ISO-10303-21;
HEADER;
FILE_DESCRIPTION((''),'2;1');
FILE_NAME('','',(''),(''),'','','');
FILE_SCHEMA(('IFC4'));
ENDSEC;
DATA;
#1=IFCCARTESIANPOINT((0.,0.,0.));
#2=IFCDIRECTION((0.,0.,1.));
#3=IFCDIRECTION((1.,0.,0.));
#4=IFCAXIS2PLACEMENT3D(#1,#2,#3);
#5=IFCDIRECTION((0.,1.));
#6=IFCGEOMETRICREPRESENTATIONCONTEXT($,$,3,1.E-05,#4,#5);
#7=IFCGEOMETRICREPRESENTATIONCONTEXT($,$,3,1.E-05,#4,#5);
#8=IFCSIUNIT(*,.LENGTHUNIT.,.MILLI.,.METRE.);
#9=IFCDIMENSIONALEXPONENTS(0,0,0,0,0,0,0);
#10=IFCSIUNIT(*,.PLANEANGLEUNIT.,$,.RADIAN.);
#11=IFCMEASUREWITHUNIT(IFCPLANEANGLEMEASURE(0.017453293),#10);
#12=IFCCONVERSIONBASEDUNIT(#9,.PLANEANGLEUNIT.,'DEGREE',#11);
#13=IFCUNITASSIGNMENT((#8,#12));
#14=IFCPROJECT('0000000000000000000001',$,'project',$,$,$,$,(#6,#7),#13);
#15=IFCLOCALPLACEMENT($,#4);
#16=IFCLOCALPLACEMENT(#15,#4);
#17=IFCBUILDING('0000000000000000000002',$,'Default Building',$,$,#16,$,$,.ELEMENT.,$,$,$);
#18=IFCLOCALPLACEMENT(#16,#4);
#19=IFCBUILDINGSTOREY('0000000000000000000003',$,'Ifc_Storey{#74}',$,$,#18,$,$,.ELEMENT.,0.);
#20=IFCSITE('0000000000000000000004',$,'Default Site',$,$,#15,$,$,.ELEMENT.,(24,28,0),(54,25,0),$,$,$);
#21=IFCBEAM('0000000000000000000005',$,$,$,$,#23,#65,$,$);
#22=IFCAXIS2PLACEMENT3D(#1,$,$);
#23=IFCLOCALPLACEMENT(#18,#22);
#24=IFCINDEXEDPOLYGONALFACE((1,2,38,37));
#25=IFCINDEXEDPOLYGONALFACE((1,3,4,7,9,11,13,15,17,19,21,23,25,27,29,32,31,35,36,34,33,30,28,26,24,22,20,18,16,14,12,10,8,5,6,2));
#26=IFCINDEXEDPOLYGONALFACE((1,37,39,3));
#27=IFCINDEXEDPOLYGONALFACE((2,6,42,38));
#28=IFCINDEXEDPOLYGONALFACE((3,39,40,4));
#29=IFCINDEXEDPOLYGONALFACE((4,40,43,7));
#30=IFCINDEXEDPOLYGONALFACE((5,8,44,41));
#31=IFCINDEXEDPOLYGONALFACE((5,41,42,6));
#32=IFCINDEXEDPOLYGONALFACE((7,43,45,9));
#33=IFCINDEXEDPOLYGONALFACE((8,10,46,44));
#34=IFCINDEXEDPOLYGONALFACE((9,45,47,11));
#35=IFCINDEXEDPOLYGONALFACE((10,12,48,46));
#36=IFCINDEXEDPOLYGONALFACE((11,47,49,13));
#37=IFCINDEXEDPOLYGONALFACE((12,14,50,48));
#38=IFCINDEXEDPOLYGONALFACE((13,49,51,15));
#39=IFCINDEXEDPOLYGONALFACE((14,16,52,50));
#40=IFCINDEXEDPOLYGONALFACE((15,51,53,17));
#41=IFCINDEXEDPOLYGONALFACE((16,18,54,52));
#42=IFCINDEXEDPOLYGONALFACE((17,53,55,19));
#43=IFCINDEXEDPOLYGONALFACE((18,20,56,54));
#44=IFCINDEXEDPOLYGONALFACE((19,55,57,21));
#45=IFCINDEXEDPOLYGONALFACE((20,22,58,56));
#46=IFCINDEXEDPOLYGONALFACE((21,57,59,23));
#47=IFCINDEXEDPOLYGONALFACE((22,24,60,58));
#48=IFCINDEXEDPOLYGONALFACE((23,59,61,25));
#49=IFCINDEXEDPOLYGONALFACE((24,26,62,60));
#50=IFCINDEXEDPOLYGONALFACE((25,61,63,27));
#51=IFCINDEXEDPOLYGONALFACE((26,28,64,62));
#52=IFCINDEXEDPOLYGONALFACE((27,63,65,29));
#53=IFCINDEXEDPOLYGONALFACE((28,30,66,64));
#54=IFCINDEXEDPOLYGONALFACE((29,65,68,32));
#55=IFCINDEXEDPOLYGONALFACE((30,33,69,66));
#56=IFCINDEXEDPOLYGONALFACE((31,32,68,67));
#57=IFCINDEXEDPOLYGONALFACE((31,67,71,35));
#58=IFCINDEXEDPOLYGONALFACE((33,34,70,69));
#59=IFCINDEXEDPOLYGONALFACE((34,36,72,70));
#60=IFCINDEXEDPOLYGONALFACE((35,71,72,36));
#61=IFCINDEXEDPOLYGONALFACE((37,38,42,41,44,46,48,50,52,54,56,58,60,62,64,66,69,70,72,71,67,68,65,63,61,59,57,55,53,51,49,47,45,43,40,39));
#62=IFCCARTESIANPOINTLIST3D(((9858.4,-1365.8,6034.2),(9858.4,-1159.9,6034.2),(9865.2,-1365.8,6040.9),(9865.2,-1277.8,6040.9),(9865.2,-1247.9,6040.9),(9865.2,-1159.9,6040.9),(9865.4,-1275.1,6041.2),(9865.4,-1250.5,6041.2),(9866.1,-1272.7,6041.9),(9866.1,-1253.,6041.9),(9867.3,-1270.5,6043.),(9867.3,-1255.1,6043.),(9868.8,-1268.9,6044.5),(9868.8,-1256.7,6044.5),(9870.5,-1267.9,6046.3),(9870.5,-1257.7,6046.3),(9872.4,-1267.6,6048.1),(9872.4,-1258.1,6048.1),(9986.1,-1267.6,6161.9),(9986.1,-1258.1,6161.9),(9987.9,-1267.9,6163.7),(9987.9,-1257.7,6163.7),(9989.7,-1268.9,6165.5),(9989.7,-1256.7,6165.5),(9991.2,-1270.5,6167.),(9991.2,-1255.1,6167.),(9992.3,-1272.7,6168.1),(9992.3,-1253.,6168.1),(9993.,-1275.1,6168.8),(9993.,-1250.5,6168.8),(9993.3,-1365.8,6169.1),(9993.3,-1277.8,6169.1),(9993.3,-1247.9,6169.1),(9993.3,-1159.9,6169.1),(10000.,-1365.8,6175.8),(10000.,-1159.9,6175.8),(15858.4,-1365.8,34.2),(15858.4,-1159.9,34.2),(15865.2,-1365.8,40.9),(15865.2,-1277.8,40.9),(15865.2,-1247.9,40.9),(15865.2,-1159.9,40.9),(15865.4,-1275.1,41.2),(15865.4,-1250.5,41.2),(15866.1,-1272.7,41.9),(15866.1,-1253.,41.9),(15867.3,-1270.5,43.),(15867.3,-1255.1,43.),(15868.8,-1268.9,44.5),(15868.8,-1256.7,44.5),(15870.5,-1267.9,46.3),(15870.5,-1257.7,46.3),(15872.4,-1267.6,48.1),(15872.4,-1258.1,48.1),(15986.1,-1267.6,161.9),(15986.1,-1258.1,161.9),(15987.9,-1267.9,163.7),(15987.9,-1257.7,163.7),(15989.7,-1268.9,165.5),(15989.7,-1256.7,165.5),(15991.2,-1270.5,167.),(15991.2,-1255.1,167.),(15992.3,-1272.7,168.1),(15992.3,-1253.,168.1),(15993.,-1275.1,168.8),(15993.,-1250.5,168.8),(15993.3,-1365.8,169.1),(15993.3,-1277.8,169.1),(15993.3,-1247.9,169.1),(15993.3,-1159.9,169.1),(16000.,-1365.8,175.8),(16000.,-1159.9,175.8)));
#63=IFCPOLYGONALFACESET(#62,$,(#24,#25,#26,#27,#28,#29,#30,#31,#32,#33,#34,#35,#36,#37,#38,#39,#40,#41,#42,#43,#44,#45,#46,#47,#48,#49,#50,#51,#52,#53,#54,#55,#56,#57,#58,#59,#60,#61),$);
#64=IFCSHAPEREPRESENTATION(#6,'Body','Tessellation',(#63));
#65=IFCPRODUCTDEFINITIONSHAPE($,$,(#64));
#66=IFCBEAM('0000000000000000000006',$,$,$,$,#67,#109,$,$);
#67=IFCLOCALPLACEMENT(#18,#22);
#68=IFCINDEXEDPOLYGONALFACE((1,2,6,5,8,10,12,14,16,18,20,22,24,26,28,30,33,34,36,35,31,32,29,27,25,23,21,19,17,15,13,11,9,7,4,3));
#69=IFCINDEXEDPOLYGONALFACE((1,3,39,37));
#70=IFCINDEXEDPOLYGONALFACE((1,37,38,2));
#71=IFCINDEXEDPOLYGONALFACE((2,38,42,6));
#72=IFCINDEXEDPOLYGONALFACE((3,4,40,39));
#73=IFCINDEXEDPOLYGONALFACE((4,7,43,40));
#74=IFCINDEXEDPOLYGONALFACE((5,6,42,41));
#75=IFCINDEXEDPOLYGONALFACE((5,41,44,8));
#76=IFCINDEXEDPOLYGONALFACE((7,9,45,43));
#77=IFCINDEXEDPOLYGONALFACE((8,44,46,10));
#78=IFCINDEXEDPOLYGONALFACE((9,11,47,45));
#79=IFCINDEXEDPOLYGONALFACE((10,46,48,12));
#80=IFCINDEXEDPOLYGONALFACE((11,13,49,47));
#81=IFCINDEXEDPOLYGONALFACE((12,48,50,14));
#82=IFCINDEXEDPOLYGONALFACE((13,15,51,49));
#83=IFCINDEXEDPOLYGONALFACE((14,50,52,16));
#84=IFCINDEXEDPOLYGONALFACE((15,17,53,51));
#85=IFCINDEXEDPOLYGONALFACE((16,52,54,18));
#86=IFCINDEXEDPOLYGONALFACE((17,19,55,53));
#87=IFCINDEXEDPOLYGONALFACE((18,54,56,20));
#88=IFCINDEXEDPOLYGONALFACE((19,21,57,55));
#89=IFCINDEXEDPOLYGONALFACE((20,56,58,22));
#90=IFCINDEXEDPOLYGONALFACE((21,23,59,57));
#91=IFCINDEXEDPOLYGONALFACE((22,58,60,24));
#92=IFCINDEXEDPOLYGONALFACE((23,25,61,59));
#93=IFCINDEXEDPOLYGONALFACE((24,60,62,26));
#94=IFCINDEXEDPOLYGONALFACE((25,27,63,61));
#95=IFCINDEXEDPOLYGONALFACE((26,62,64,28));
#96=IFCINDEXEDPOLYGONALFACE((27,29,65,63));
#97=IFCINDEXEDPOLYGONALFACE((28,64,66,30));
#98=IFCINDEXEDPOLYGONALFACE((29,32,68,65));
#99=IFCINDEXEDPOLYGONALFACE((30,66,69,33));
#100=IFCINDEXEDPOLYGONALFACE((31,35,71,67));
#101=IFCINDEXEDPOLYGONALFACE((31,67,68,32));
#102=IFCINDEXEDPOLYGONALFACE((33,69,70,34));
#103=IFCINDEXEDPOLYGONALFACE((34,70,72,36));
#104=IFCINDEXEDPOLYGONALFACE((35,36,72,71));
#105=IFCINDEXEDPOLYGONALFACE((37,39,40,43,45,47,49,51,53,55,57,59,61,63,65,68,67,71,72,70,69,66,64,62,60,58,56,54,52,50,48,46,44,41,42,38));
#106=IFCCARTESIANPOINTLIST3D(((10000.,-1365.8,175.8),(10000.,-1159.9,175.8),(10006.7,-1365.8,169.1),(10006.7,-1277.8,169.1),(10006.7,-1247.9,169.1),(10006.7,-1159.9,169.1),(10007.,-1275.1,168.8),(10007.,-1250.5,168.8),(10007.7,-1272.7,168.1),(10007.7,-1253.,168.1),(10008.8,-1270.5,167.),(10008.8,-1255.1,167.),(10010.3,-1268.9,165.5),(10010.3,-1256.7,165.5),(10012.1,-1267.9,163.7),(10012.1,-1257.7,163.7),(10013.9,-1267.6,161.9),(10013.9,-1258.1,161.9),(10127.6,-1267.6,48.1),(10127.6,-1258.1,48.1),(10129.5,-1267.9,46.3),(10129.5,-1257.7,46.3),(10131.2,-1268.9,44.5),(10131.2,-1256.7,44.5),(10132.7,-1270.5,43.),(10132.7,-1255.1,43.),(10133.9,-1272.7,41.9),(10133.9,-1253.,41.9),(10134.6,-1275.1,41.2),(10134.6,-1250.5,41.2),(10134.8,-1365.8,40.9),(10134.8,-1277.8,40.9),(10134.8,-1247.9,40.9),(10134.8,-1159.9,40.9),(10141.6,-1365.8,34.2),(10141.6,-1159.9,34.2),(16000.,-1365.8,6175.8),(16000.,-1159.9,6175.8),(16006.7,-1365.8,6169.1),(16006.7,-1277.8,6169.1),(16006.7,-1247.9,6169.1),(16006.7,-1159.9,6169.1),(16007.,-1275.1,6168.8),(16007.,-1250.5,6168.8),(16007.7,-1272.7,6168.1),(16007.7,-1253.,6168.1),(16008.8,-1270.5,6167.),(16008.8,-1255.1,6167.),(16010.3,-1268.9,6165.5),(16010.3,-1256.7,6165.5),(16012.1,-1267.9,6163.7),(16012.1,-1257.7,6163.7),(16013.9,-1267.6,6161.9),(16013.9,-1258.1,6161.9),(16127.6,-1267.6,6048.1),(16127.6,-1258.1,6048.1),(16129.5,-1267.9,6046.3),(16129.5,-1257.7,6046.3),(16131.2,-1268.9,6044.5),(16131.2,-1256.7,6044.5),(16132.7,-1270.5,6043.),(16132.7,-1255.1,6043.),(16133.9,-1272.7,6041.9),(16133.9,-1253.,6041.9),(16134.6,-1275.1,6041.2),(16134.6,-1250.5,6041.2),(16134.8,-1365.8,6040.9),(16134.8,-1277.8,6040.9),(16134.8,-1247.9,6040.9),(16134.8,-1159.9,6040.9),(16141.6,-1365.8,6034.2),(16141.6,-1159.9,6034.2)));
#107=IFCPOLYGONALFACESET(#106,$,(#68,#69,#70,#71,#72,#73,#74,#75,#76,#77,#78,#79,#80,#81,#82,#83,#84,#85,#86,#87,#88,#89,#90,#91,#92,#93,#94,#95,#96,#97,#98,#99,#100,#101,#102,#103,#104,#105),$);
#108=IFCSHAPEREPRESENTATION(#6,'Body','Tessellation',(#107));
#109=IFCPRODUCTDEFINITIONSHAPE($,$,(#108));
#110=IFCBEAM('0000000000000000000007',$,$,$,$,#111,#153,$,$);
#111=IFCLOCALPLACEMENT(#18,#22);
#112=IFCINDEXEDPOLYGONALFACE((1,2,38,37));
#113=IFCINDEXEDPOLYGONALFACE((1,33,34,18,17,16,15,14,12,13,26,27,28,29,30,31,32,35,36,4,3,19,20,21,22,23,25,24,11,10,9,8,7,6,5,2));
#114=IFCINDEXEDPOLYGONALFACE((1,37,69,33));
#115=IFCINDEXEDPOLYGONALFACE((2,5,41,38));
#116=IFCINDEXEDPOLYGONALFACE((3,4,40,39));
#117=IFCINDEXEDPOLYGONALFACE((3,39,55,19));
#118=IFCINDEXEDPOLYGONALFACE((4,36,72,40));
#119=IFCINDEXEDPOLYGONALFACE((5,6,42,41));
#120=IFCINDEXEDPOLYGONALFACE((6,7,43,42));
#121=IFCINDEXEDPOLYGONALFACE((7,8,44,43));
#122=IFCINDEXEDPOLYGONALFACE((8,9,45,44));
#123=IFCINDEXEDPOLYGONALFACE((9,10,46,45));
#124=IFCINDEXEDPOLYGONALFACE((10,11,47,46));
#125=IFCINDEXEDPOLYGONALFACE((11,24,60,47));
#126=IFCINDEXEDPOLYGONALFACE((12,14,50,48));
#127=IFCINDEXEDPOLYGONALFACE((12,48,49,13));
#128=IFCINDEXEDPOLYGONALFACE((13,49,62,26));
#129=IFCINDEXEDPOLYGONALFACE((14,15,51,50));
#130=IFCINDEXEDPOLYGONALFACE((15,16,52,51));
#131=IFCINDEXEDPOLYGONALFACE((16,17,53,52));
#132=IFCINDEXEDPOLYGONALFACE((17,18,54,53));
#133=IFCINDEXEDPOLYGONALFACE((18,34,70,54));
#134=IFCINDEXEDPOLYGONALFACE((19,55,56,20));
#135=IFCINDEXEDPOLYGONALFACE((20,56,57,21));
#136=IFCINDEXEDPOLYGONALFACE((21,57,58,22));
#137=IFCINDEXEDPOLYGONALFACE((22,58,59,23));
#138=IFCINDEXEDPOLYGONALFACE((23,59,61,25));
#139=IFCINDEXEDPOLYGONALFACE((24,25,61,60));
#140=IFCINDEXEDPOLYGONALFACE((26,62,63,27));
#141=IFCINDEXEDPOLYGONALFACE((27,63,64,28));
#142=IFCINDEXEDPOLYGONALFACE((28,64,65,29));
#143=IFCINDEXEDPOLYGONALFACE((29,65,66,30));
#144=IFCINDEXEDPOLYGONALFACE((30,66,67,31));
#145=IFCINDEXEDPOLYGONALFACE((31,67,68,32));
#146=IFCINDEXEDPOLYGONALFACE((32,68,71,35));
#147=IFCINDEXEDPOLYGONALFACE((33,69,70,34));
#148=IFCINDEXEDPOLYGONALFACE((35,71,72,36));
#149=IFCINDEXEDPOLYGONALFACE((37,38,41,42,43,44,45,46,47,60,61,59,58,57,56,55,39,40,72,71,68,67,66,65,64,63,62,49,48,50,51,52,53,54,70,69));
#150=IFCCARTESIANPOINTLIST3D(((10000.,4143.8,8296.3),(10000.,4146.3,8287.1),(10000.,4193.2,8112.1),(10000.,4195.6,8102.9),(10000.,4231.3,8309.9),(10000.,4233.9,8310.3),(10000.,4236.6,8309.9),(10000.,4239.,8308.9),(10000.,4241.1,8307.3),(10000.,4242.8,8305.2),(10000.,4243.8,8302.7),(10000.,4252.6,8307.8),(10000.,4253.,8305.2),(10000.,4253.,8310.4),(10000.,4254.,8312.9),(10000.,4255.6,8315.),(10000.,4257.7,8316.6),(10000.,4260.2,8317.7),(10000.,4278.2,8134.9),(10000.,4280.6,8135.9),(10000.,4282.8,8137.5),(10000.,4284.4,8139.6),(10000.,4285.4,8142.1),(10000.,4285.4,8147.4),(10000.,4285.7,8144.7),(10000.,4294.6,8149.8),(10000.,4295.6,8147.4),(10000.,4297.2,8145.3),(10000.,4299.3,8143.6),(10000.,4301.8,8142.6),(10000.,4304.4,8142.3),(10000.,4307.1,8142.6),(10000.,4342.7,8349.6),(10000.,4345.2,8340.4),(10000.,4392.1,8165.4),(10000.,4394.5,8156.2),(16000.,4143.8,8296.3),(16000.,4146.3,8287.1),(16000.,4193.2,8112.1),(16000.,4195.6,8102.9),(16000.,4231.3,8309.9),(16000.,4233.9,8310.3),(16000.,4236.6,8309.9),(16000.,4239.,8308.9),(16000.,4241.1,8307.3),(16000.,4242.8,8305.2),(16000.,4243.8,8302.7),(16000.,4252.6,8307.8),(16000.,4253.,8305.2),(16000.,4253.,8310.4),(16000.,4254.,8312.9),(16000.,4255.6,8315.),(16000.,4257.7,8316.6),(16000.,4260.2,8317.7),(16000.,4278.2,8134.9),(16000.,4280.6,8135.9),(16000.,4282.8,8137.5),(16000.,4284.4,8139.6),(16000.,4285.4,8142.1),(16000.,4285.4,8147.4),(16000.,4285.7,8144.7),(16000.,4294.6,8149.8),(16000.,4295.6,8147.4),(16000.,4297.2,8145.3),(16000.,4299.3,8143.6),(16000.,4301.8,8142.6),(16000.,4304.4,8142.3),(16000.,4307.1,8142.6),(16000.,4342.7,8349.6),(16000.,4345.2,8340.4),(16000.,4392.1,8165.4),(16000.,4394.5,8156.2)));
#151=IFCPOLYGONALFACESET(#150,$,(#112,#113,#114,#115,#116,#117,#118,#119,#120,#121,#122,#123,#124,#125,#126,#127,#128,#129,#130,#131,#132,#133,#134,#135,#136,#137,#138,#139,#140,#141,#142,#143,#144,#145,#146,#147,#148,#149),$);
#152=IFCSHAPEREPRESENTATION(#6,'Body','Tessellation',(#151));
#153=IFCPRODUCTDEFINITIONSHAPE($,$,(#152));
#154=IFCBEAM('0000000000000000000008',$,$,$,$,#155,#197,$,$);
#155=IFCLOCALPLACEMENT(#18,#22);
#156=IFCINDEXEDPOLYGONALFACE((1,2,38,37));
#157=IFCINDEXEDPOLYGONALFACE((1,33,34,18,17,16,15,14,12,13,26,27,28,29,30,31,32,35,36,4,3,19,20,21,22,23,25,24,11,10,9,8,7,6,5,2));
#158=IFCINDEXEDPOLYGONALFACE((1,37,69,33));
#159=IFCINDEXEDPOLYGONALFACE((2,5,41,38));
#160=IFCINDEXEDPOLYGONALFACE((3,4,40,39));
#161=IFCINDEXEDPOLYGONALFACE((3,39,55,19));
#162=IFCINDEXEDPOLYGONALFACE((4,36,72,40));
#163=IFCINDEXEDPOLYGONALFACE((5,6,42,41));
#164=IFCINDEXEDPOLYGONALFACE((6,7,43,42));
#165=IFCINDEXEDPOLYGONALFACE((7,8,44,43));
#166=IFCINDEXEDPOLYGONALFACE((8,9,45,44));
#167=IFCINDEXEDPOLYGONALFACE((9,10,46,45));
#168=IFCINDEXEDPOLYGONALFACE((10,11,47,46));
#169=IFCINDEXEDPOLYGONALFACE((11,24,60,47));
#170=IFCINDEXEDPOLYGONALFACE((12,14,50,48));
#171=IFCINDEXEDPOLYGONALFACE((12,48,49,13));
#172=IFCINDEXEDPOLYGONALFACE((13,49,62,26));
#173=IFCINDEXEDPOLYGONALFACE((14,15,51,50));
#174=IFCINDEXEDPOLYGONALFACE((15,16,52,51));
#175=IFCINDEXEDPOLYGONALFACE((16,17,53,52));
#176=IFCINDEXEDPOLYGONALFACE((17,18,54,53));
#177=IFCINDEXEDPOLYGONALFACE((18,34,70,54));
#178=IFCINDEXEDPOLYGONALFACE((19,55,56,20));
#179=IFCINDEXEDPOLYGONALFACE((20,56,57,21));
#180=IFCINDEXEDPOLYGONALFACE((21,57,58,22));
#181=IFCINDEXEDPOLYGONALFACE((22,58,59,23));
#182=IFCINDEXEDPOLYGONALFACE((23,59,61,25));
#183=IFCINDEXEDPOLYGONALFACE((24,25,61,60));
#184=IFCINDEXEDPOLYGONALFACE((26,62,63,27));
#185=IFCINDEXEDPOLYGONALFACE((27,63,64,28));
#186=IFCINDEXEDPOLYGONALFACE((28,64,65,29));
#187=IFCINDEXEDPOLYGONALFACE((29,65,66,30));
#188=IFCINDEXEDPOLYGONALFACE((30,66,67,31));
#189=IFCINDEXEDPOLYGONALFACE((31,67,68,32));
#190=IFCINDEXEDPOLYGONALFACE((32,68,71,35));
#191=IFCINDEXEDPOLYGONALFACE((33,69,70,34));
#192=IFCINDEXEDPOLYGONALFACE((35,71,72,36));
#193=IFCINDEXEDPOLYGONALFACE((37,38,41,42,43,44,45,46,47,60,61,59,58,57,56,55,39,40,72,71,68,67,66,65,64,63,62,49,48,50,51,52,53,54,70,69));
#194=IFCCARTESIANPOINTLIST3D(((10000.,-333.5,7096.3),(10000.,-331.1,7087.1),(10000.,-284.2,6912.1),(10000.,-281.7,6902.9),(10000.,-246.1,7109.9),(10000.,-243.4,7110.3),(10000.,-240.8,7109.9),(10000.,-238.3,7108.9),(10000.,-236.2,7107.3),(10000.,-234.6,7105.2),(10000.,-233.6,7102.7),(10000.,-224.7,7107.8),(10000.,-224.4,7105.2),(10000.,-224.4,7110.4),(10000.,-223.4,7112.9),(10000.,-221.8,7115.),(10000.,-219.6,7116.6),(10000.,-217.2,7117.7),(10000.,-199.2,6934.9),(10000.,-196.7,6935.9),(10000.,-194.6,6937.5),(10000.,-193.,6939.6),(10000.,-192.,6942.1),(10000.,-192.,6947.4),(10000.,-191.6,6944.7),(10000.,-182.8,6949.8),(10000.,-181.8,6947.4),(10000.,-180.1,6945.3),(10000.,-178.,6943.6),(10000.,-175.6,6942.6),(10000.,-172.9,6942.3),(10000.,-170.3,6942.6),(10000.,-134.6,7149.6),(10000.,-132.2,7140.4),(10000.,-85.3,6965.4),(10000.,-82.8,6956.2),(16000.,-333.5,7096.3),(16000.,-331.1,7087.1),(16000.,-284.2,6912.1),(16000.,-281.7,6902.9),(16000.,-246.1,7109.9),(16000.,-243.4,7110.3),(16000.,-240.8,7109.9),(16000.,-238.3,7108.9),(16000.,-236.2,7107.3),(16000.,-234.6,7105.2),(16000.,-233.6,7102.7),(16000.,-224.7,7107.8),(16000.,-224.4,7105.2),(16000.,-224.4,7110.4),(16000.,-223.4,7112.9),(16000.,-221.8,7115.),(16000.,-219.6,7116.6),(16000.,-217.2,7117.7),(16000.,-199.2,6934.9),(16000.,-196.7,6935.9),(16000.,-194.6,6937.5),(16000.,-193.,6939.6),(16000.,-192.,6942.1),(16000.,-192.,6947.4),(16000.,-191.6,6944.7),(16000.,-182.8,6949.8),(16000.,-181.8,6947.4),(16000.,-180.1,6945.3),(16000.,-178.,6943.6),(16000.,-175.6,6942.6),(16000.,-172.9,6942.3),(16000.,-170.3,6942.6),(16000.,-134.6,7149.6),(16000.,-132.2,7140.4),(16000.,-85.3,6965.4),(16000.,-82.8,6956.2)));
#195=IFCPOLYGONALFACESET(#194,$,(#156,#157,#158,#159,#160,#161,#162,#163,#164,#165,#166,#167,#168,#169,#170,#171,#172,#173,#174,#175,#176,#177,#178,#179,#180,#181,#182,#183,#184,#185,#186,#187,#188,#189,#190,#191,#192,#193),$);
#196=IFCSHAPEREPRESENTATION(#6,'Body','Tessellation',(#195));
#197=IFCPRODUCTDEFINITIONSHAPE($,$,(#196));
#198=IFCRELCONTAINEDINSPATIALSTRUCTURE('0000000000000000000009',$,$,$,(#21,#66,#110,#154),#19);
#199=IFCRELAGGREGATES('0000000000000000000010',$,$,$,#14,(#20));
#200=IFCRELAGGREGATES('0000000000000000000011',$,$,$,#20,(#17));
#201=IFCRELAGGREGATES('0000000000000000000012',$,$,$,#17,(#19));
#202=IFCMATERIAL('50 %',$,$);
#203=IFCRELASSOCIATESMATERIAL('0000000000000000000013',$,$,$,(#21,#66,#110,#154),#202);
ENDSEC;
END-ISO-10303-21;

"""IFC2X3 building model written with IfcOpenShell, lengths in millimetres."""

from ifc_helpers import new_model, entity, si_unit, converted_unit, direction, frame, origin_with_axes, origin_2d_with_axis, place, context, project, spatial, i_section, extrude, material, element, save


model = new_model("IFC2X3")

# Units and contexts
context_of_model_1 = context(None, 3, precision=1e-05, world=origin_with_axes(), true_north=direction((0.0, 1.0)))
context_of_model_2 = context(None, 3, precision=1e-05, world=origin_with_axes(), true_north=direction((0.0, 1.0)))
ifc_project = project(units=[si_unit("LENGTHUNIT", "METRE", prefix="MILLI"), converted_unit("PLANEANGLEUNIT", "DEGREE", entity("IfcPlaneAngleMeasure", 0.017453293), si_unit("PLANEANGLEUNIT", "RADIAN"), dimensions=[0, 0, 0, 0, 0, 0, 0])], contexts=[context_of_model_1, context_of_model_2])

# Site, building, storey
site_placement = place(None, origin_with_axes())
site = spatial("IfcSite", under=ifc_project, at=site_placement, Name="Default Site", CompositionType="ELEMENT", RefLatitude=(24, 28, 0), RefLongitude=(54, 25, 0))
building_placement = place(site_placement, origin_with_axes())
building = spatial("IfcBuilding", under=site, at=building_placement, Name="Default Building", CompositionType="ELEMENT")
storey_placement = place(building_placement, origin_with_axes())
storey = spatial("IfcBuildingStorey", under=building, at=storey_placement, Name="Ifc_Storey{#74}", CompositionType="ELEMENT", Elevation=0.0)

# Shared definitions
ifc_material_1 = material(Name="50 %")

# Beams
beam_1_placement = place(storey_placement, frame((15929.2, -1262.8, 105.0), z_axis=(0.0, 0.0, 1.0), x_axis=(-1.0, 0.0, 0.0)))
element("IfcBeam", 1, at=beam_1_placement, inside=storey, material=ifc_material_1, context=context_of_model_1, shape_type="SweptSolid", body=[
    extrude(i_section(OverallWidth=205.9, OverallDepth=200.2, WebThickness=9.5, FlangeThickness=9.5, FilletRadius=10.2, at=origin_2d_with_axis()), frame((0.0, 0.0, 0.0), z_axis=(0.707107, 0.0, 0.707107), x_axis=(0.0, 1.0, 0.0)), (0.0, 0.0, 1.0), 8485.3),
])
beam_2_placement = place(storey_placement, frame((10070.8, -1262.8, 105.0), z_axis=(0.0, 0.0, 1.0), x_axis=(-1.0, 0.0, 0.0)))
element("IfcBeam", 2, at=beam_2_placement, inside=storey, material=ifc_material_1, context=context_of_model_1, shape_type="SweptSolid", body=[
    extrude(i_section(OverallWidth=205.9, OverallDepth=200.2, WebThickness=9.5, FlangeThickness=9.5, FilletRadius=10.2, at=origin_2d_with_axis()), frame((0.0, 0.0, 0.0), z_axis=(-0.707107, 0.0, 0.707107), x_axis=(0.0, 1.0, 0.0)), (0.0, 0.0, 1.0), 8485.3),
])
for number, where, z_axis, x_axis in (
    (3, (10000.0, 4269.2, 8226.3), (0.0, -0.258819, 0.965926), (-1.0, 0.0, 0.0)),
    (4, (10000.0, -208.2, 7026.3), (0.0, -0.258819, 0.965926), (-1.0, 0.0, 0.0)),
):
    element("IfcBeam", number, at=place(storey_placement, frame(where, z_axis=z_axis, x_axis=x_axis)), inside=storey, material=ifc_material_1, context=context_of_model_1, shape_type="SweptSolid", body=[
        extrude(i_section(OverallWidth=205.9, OverallDepth=200.2, WebThickness=9.5, FlangeThickness=9.5, FilletRadius=10.2, at=origin_2d_with_axis()), frame((0.0, 0.0, 0.0), z_axis=(-1.0, 0.0, 0.0), x_axis=(0.0, 1.0, 0.0)), (0.0, 0.0, 1.0), 6000.0),
    ])

save(model, "model.ifc")
